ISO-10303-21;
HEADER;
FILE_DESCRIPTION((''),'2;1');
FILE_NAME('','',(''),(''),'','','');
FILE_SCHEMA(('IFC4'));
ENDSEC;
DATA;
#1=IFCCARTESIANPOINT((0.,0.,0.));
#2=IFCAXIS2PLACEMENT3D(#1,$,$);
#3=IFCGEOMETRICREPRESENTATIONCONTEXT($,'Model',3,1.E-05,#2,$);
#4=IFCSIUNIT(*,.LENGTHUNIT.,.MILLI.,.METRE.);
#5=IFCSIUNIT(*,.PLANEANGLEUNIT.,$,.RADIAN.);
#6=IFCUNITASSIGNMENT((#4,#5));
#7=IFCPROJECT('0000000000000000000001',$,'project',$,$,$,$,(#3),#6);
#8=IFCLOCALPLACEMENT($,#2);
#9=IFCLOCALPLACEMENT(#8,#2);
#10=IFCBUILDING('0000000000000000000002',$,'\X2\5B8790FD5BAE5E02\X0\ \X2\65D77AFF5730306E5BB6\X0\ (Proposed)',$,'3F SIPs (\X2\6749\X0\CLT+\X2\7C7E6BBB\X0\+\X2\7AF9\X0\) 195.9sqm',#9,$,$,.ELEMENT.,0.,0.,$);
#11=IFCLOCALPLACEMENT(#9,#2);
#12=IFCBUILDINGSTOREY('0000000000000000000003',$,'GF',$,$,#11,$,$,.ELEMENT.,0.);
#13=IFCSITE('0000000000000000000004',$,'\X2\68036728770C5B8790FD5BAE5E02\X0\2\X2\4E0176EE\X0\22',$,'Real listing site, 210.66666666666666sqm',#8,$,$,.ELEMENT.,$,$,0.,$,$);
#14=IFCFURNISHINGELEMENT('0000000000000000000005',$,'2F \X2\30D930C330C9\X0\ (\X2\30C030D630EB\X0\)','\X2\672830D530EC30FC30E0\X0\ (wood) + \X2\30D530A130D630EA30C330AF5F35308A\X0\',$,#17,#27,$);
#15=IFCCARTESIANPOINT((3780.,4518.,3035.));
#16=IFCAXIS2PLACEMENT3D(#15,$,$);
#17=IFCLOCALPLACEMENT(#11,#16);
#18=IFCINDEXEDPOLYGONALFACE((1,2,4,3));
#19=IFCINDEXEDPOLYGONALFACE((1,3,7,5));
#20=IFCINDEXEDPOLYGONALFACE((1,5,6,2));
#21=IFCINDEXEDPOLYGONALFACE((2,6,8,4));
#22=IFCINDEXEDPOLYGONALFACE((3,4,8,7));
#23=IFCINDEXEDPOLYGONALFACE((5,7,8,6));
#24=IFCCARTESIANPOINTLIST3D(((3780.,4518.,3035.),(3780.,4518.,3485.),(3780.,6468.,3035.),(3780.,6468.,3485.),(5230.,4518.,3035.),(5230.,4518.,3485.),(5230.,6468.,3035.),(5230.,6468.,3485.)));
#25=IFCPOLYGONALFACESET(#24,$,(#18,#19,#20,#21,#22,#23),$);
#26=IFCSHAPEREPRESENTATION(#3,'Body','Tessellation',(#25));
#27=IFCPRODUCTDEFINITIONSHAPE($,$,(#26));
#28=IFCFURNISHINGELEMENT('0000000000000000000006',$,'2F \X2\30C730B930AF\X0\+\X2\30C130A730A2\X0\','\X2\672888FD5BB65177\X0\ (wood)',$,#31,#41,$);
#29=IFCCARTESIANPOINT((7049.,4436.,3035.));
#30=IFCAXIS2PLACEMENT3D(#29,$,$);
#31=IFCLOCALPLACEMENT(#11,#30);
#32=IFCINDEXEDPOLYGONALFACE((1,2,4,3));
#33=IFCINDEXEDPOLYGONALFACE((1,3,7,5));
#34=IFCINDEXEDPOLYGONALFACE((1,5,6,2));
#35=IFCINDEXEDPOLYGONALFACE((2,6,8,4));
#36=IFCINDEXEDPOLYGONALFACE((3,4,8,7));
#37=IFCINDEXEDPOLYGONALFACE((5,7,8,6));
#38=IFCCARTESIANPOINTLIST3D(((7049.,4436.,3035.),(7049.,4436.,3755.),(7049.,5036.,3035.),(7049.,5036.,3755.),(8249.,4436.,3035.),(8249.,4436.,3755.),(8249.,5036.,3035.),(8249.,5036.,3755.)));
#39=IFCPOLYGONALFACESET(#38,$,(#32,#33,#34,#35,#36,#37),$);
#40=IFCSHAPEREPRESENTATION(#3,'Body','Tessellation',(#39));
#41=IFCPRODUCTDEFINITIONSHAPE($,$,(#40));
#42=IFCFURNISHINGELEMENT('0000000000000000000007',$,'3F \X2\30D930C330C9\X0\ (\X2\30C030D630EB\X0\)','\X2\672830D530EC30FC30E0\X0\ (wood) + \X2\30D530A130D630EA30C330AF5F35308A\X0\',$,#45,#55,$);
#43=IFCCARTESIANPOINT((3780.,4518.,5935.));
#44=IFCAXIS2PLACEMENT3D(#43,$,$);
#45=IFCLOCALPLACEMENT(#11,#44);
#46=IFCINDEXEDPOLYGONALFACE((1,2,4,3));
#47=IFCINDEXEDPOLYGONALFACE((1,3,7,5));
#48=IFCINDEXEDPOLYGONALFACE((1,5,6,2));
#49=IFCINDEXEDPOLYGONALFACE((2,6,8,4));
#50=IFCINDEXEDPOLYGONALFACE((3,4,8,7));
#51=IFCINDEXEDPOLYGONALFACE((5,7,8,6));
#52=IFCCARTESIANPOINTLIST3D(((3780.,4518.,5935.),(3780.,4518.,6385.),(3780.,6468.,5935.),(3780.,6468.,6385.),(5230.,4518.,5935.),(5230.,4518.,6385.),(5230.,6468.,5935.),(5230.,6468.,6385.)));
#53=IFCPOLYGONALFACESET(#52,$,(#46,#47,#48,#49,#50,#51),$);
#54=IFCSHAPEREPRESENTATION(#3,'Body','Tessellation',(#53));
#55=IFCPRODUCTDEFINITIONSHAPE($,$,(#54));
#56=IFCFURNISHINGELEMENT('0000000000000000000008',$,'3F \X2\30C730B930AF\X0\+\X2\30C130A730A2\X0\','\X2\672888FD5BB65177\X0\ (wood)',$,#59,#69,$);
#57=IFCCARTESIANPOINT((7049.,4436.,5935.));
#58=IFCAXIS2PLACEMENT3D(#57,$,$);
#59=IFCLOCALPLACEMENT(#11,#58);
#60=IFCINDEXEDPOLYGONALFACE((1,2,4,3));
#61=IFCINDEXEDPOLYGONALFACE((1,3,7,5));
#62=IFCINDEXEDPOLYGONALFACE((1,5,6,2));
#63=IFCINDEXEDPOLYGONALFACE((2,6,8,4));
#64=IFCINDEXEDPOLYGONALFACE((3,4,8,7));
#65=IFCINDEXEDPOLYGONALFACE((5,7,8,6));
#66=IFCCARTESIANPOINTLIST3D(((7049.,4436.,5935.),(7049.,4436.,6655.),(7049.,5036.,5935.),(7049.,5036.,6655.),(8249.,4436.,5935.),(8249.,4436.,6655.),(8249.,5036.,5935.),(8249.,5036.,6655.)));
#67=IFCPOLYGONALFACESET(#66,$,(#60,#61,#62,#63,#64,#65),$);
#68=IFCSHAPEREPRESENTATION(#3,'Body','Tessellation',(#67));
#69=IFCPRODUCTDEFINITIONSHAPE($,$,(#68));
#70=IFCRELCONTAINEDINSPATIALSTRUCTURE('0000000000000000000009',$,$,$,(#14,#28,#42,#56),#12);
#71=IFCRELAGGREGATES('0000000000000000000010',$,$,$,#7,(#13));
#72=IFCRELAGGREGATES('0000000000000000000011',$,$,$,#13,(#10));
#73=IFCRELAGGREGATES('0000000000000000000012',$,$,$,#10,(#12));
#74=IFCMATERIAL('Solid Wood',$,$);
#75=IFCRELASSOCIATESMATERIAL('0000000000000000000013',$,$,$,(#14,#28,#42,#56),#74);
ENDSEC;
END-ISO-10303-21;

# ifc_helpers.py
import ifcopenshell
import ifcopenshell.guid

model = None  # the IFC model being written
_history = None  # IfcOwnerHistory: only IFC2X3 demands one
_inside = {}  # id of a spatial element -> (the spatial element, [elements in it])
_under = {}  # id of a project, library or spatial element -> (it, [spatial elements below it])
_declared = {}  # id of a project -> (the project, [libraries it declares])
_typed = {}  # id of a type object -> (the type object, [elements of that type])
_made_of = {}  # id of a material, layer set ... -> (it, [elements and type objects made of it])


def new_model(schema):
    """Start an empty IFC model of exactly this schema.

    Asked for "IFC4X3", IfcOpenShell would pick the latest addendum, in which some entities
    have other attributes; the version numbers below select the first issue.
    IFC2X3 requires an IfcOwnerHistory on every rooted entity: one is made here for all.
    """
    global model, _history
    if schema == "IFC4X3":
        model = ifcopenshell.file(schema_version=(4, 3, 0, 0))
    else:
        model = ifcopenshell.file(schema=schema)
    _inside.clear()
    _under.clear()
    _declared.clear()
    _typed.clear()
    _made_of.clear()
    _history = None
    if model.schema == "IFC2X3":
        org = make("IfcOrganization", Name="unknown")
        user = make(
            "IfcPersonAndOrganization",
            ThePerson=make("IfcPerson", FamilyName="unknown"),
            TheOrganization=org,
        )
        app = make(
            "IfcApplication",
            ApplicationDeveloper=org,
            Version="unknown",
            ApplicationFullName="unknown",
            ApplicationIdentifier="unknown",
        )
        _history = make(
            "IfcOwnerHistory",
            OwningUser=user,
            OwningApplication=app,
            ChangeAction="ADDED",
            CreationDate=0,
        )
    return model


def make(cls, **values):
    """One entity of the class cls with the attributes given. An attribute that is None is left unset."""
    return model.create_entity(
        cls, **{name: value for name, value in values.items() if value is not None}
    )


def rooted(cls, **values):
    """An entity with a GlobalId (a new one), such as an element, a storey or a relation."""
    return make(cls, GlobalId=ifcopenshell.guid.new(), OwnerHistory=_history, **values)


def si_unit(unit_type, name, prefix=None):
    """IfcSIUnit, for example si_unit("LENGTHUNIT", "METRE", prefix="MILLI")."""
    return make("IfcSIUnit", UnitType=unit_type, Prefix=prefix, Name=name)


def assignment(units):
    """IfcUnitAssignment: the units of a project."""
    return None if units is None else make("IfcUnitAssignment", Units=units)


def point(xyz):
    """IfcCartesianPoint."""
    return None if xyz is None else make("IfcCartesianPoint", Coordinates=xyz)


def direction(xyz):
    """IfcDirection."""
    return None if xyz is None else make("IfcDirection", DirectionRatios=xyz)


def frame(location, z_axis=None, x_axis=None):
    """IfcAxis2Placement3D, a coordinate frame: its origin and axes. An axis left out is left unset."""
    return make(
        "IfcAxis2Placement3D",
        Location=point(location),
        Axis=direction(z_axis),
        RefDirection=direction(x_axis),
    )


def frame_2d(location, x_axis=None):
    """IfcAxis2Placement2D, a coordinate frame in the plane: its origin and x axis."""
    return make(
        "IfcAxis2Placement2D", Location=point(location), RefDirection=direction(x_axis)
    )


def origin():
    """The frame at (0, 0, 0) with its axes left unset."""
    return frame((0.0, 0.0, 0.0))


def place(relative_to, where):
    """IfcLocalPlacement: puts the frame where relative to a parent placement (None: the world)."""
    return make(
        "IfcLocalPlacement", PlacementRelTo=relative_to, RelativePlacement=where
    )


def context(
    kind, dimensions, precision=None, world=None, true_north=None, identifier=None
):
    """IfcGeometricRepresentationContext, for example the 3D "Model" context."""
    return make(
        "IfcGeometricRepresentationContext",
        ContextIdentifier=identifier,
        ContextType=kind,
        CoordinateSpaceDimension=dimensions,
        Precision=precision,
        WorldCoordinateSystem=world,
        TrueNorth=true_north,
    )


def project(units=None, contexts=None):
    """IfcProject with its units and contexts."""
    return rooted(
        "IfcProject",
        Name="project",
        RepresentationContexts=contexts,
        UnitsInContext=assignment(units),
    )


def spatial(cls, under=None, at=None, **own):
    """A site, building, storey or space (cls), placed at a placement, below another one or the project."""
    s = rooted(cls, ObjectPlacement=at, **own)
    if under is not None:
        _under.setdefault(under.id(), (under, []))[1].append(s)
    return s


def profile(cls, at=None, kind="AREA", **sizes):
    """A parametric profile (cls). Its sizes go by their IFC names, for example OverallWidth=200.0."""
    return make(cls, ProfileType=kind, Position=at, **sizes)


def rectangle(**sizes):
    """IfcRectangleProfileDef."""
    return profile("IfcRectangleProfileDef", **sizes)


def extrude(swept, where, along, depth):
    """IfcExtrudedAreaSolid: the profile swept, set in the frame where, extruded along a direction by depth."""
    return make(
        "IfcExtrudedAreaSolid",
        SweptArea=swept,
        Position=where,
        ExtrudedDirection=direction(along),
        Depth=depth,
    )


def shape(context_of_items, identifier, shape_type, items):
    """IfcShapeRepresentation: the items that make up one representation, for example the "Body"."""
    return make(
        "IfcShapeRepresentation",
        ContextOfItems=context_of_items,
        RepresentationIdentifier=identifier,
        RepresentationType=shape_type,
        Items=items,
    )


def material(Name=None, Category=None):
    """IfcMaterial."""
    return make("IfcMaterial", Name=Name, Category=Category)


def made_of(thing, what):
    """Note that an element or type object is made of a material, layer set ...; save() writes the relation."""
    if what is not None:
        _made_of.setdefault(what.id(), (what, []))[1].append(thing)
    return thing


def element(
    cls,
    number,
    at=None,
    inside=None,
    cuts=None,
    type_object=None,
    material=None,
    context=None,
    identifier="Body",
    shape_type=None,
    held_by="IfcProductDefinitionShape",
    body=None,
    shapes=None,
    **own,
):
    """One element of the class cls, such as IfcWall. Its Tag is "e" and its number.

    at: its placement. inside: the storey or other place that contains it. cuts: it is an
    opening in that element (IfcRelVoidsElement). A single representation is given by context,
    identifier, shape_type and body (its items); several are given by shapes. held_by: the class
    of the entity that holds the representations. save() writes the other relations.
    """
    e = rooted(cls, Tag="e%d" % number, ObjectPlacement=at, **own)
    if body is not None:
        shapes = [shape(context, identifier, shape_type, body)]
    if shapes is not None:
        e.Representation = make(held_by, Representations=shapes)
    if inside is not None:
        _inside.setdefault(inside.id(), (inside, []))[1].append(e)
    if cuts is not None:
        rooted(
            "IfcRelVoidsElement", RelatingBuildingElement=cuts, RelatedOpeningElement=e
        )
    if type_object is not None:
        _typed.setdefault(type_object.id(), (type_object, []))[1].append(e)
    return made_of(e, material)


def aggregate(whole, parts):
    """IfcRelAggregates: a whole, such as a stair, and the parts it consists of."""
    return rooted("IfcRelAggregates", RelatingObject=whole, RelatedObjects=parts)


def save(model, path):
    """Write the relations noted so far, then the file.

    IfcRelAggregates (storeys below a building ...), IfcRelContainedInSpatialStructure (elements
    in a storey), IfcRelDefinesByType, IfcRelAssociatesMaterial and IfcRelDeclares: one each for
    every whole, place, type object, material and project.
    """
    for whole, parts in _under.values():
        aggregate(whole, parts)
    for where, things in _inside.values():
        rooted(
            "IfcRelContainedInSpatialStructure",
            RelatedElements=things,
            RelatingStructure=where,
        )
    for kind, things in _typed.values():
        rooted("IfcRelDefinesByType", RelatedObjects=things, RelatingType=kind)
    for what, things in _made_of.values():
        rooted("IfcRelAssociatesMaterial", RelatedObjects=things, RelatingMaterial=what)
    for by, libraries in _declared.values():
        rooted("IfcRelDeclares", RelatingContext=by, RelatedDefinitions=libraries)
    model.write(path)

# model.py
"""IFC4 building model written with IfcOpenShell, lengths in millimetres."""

from ifc_helpers import new_model, si_unit, frame, frame_2d, origin, place, context, project, spatial, rectangle, extrude, material, element, save


model = new_model("IFC4")

# Units and contexts
model_context = context("Model", 3, precision=1e-05, world=origin())
ifc_project = project(units=[si_unit("LENGTHUNIT", "METRE", prefix="MILLI"), si_unit("PLANEANGLEUNIT", "RADIAN")], contexts=[model_context])

# Site, building, storey
site_placement = place(None, origin())
site = spatial("IfcSite", under=ifc_project, at=site_placement, Name="栃木県宇都宮市2丁目22", ObjectType="Real listing site, 210.66666666666666sqm", CompositionType="ELEMENT", RefElevation=0.0)
building_placement = place(site_placement, origin())
building = spatial("IfcBuilding", under=site, at=building_placement, Name="宇都宮市 旗竿地の家 (Proposed)", ObjectType="3F SIPs (杉CLT+籾殻+竹) 195.9sqm", CompositionType="ELEMENT", ElevationOfRefHeight=0.0, ElevationOfTerrain=0.0)
storey_placement = place(building_placement, origin())
storey = spatial("IfcBuildingStorey", under=building, at=storey_placement, Name="GF", CompositionType="ELEMENT", Elevation=0.0)

# Shared definitions
ifc_material_1 = material(Name="Solid Wood")

# Furnishing elements
furnishing_1_placement = place(storey_placement, frame((3780.0, 4518.0, 3035.0)))
element("IfcFurnishingElement", 1, at=furnishing_1_placement, inside=storey, material=ifc_material_1, Name="2F ベッド (ダブル)", Description="木フレーム (wood) + ファブリック張り", context=model_context, shape_type="SweptSolid", body=[
    extrude(rectangle(XDim=1450.0, YDim=1950.0, at=frame_2d((725.0, 975.0))), frame((3780.0, 4518.0, 3035.0)), (0.0, 0.0, 1.0), 450.0),
])
furnishing_2_placement = place(storey_placement, frame((7049.0, 4436.0, 3035.0)))
element("IfcFurnishingElement", 2, at=furnishing_2_placement, inside=storey, material=ifc_material_1, Name="2F デスク+チェア", Description="木製家具 (wood)", context=model_context, shape_type="SweptSolid", body=[
    extrude(rectangle(XDim=1200.0, YDim=600.0, at=frame_2d((600.0, 300.0))), frame((7049.0, 4436.0, 3035.0)), (0.0, 0.0, 1.0), 720.0),
])
furnishing_3_placement = place(storey_placement, frame((3780.0, 4518.0, 5935.0)))
element("IfcFurnishingElement", 3, at=furnishing_3_placement, inside=storey, material=ifc_material_1, Name="3F ベッド (ダブル)", Description="木フレーム (wood) + ファブリック張り", context=model_context, shape_type="SweptSolid", body=[
    extrude(rectangle(XDim=1450.0, YDim=1950.0, at=frame_2d((725.0, 975.0))), frame((3780.0, 4518.0, 5935.0)), (0.0, 0.0, 1.0), 450.0),
])
furnishing_4_placement = place(storey_placement, frame((7049.0, 4436.0, 5935.0)))
element("IfcFurnishingElement", 4, at=furnishing_4_placement, inside=storey, material=ifc_material_1, Name="3F デスク+チェア", Description="木製家具 (wood)", context=model_context, shape_type="SweptSolid", body=[
    extrude(rectangle(XDim=1200.0, YDim=600.0, at=frame_2d((600.0, 300.0))), frame((7049.0, 4436.0, 5935.0)), (0.0, 0.0, 1.0), 720.0),
])

save(model, "model.ifc")
